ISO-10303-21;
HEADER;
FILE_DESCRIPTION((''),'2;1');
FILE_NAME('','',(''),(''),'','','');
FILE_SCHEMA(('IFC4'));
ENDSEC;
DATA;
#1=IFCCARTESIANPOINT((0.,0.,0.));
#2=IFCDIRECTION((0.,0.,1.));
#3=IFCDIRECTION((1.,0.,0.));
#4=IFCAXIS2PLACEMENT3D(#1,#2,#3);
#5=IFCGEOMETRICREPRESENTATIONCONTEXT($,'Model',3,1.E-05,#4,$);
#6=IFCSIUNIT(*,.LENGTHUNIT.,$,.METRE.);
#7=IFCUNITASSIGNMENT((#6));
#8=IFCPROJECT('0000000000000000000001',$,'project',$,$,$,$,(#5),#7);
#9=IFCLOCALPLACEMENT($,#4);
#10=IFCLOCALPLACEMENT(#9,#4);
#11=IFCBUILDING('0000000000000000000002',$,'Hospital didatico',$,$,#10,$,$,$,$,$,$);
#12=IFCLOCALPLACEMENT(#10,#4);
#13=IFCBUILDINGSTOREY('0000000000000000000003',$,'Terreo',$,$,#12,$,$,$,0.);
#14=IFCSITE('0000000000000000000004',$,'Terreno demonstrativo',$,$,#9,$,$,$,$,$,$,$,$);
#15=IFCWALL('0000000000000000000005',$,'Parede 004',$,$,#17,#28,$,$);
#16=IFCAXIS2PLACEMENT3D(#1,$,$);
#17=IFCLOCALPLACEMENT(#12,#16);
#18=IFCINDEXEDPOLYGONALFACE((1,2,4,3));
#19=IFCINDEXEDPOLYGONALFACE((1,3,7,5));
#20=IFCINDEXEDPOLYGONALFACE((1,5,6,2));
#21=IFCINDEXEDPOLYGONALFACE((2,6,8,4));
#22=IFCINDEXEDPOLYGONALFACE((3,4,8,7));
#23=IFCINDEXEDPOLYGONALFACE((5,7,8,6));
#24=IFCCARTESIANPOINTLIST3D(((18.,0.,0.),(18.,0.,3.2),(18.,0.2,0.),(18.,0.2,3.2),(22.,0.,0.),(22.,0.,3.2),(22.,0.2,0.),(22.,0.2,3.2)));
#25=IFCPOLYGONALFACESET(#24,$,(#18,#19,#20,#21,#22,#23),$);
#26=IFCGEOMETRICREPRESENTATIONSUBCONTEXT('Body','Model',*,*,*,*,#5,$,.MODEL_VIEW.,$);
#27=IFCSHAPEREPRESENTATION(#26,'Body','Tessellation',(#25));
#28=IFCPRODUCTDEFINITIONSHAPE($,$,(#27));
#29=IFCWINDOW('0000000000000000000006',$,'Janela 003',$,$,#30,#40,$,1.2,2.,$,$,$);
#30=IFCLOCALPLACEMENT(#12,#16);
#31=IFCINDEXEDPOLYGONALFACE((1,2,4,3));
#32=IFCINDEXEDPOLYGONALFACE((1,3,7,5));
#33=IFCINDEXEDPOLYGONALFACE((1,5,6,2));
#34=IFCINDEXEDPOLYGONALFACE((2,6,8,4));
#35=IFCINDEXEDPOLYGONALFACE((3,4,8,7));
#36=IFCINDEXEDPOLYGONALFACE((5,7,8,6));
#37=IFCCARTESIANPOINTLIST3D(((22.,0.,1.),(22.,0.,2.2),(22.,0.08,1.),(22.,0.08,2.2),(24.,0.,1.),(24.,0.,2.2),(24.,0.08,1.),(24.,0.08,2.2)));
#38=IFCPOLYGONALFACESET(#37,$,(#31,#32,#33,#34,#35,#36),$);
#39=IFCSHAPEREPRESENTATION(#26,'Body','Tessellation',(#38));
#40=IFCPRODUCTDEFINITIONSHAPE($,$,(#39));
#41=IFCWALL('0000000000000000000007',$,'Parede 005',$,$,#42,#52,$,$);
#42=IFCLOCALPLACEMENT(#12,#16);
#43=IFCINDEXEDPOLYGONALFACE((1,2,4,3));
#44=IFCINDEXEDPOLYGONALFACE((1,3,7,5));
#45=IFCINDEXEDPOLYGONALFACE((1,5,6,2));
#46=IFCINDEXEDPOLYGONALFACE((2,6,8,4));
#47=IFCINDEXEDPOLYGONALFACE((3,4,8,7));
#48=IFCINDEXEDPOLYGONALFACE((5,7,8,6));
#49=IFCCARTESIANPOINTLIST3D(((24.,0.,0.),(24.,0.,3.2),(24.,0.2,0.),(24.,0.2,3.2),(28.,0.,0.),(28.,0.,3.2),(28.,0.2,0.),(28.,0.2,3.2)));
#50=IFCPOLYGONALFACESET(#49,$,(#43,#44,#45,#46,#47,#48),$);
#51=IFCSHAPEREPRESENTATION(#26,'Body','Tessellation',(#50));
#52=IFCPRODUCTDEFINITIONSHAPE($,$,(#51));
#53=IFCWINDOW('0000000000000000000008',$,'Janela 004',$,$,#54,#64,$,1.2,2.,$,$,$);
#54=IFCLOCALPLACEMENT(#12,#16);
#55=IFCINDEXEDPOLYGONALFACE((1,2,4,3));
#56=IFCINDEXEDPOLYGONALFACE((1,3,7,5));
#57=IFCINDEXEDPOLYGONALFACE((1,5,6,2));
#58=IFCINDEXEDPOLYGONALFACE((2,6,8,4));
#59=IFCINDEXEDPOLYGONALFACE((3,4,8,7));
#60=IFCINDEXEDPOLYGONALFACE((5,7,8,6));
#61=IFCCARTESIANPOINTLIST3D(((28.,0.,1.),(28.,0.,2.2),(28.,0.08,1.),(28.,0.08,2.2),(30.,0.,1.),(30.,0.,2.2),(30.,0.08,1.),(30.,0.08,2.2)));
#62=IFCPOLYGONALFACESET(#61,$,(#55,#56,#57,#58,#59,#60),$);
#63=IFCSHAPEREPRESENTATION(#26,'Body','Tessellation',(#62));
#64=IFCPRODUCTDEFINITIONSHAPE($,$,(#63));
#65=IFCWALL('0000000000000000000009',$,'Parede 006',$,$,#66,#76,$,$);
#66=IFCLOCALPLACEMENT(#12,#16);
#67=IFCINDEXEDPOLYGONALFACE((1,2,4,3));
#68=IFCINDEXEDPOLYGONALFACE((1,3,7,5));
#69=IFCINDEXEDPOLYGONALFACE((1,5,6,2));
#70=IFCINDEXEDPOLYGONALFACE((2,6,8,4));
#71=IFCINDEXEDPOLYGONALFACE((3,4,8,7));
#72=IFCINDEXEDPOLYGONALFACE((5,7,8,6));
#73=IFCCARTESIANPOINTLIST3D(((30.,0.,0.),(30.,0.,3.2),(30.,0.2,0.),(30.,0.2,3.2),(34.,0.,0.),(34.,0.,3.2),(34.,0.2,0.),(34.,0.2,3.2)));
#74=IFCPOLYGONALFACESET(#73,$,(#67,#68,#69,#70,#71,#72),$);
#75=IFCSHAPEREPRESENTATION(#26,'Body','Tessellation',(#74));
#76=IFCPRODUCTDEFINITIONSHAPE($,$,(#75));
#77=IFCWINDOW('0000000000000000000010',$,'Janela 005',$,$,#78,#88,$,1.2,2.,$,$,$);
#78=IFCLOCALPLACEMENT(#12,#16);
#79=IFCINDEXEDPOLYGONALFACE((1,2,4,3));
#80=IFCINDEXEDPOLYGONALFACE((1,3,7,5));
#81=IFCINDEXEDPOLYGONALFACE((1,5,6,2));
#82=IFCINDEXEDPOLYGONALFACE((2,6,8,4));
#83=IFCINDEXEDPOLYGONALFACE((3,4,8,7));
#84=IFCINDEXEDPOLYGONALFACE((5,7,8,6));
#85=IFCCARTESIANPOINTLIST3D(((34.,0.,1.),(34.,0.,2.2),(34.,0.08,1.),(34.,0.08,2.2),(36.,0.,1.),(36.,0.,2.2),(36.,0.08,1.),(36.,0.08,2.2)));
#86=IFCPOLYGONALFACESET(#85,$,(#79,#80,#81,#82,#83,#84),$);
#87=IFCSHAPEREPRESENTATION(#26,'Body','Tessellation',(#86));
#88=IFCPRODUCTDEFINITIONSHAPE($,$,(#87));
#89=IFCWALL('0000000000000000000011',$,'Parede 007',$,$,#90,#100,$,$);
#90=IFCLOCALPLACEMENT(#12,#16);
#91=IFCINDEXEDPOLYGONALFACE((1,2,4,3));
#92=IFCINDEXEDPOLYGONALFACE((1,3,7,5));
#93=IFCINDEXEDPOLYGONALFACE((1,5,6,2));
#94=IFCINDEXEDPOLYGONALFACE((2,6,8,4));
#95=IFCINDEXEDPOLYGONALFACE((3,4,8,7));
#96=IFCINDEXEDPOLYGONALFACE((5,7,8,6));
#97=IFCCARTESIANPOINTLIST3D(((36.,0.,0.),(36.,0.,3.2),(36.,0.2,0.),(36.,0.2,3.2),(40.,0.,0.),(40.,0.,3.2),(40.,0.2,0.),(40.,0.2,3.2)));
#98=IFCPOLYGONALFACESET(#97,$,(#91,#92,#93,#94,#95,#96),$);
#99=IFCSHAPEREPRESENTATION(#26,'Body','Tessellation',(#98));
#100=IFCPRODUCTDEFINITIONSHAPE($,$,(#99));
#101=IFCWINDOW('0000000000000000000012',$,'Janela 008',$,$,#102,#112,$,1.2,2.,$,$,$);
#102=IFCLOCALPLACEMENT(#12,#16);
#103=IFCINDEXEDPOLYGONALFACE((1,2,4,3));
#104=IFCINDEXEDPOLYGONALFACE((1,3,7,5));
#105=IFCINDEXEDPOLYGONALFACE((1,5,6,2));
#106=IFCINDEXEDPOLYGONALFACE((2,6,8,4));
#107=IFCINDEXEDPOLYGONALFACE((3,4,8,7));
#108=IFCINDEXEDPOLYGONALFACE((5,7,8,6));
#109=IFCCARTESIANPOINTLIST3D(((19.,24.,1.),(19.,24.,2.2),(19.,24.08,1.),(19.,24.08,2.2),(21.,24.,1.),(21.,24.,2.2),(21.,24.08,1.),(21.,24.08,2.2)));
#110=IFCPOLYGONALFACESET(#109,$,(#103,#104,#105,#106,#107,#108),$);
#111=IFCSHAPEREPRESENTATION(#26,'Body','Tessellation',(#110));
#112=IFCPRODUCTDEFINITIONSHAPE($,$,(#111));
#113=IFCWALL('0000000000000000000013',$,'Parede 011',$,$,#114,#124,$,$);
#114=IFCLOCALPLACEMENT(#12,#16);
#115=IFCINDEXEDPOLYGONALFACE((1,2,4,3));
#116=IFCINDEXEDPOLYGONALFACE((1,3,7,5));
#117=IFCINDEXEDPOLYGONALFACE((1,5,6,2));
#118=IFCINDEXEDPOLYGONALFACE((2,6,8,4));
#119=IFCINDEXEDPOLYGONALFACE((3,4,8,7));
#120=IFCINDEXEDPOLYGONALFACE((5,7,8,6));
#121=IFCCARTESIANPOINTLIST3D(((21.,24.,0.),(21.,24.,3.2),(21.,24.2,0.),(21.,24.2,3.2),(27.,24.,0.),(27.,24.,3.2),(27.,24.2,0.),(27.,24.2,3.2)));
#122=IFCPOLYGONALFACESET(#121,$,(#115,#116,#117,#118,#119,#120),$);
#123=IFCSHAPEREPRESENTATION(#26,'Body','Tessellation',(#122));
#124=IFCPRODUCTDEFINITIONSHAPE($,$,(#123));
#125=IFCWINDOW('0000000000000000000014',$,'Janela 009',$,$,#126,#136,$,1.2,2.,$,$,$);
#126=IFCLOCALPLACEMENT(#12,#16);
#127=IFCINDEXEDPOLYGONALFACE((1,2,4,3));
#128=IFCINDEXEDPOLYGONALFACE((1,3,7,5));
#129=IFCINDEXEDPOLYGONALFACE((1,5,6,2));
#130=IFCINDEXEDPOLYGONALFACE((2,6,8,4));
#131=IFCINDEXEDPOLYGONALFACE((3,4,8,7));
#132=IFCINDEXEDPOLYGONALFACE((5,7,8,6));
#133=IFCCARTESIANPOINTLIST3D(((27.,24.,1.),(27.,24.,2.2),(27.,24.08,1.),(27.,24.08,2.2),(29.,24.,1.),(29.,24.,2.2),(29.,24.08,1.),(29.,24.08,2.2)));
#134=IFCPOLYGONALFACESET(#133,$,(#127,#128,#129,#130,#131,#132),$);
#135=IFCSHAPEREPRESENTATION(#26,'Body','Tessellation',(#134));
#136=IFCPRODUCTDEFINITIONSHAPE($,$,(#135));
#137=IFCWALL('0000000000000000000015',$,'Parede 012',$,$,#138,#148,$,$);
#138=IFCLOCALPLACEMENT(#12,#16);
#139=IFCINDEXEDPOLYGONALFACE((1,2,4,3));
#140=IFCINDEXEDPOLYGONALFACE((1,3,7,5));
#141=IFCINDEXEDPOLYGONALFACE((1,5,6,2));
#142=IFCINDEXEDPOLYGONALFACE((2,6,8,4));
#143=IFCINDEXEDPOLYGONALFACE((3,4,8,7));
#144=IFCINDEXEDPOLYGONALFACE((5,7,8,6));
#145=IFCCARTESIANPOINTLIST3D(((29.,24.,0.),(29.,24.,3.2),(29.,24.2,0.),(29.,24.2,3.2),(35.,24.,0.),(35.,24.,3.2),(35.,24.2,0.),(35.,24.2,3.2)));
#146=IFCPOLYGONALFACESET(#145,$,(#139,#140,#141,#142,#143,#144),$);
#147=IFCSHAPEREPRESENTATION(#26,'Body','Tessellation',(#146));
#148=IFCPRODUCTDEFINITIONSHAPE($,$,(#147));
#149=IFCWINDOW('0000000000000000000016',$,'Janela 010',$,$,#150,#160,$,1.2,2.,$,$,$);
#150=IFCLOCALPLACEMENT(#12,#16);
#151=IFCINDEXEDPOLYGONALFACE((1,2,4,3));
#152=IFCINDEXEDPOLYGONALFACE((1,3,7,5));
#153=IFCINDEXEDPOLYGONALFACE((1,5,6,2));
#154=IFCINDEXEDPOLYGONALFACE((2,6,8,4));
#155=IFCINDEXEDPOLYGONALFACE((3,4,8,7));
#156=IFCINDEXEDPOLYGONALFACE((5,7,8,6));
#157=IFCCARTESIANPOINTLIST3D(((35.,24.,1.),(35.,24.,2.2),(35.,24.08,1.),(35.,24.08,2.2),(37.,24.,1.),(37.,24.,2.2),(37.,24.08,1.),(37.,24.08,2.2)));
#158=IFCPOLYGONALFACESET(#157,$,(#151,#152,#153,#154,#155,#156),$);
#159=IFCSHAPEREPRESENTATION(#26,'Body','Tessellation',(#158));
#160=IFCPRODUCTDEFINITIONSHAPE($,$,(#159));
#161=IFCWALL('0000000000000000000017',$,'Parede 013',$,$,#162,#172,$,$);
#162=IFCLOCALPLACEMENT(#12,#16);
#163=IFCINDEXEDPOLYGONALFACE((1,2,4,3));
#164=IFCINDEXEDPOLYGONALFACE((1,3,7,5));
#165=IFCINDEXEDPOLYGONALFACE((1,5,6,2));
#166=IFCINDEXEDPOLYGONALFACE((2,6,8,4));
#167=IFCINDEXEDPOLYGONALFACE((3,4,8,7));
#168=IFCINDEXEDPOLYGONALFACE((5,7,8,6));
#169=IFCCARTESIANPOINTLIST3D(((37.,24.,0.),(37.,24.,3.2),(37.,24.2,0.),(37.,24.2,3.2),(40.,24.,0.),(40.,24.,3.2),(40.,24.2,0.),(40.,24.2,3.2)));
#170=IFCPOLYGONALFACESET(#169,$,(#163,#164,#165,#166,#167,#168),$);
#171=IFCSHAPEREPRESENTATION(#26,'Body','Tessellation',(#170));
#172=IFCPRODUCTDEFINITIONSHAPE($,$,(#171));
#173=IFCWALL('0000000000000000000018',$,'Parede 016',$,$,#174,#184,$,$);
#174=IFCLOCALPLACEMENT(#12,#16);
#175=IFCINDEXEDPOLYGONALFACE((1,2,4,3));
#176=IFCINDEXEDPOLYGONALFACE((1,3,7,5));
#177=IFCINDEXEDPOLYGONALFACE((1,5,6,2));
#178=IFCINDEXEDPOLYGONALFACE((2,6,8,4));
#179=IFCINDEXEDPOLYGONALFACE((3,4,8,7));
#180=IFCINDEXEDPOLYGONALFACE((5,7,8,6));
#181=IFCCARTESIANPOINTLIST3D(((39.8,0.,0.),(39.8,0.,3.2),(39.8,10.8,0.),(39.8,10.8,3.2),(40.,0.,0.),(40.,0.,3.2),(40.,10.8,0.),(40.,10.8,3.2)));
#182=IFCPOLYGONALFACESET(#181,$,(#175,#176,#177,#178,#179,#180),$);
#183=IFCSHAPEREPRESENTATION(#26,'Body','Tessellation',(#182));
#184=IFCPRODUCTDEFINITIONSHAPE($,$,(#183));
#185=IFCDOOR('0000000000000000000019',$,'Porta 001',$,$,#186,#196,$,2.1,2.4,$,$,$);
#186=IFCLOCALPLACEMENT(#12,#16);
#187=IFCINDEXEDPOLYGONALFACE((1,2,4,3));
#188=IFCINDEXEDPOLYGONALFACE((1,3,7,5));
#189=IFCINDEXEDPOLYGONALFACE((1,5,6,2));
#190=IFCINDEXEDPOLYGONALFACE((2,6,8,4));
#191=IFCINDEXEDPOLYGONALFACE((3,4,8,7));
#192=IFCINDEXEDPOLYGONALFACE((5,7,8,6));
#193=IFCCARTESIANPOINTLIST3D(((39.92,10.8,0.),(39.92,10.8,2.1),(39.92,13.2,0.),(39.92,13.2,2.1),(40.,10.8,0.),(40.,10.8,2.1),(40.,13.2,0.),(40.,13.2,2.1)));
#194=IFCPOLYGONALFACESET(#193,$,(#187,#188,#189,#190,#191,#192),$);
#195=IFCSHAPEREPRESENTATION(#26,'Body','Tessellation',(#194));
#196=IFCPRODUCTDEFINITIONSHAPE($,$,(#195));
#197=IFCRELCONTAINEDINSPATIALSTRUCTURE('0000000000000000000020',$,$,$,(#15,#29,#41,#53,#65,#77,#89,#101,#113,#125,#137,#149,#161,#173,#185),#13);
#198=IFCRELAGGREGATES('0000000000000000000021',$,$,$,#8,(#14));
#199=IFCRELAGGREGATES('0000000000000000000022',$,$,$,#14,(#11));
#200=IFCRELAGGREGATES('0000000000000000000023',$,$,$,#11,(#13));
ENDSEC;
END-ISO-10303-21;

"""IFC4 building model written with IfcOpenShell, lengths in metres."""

from ifc_helpers import new_model, si_unit, frame, origin_with_axes, place, context, subcontext, project, spatial, indexed_curve, outline, extrude, element, save


model = new_model("IFC4")

# Units and contexts
model_context = context("Model", 3, precision=1e-05, world=origin_with_axes())
body_context = subcontext(model_context, "Body", "Model", "MODEL_VIEW")
ifc_project = project(units=[si_unit("LENGTHUNIT", "METRE")], contexts=[model_context])

# Site, building, storey
site_placement = place(None, origin_with_axes())
site = spatial("IfcSite", under=ifc_project, at=site_placement, Name="Terreno demonstrativo")
building_placement = place(site_placement, origin_with_axes())
building = spatial("IfcBuilding", under=site, at=building_placement, Name="Hospital didatico")
storey_placement = place(building_placement, origin_with_axes())
storey = spatial("IfcBuildingStorey", under=building, at=storey_placement, Name="Terreo", Elevation=0.0)

# Wall
wall_1_placement = place(storey_placement, frame((18.0, 0.0, 0.0), z_axis=(0.0, 0.0, 1.0), x_axis=(1.0, 0.0, 0.0)))
element("IfcWall", 1, at=wall_1_placement, inside=storey, Name="Parede 004", context=body_context, shape_type="SweptSolid", body=[
    extrude(outline(indexed_curve([(0.0, 0.0), (0.0, 0.2), (4.0, 0.2), (4.0, 0.0), (0.0, 0.0)], self_intersect=False)), origin_with_axes(), (0.0, 0.0, 1.0), 3.2),
])

# Window
window_1_placement = place(storey_placement, frame((22.0, 0.0, 1.0), z_axis=(0.0, 0.0, 1.0), x_axis=(1.0, 0.0, 0.0)))
element("IfcWindow", 2, at=window_1_placement, inside=storey, Name="Janela 003", OverallHeight=1.2, OverallWidth=2.0, context=body_context, shape_type="SweptSolid", body=[
    extrude(outline(indexed_curve([(0.0, 0.0), (0.0, 0.08), (2.0, 0.08), (2.0, 0.0), (0.0, 0.0)], self_intersect=False)), origin_with_axes(), (0.0, 0.0, 1.0), 1.2),
])

# Wall
wall_2_placement = place(storey_placement, frame((24.0, 0.0, 0.0), z_axis=(0.0, 0.0, 1.0), x_axis=(1.0, 0.0, 0.0)))
element("IfcWall", 3, at=wall_2_placement, inside=storey, Name="Parede 005", context=body_context, shape_type="SweptSolid", body=[
    extrude(outline(indexed_curve([(0.0, 0.0), (0.0, 0.2), (4.0, 0.2), (4.0, 0.0), (0.0, 0.0)], self_intersect=False)), origin_with_axes(), (0.0, 0.0, 1.0), 3.2),
])

# Window
window_2_placement = place(storey_placement, frame((28.0, 0.0, 1.0), z_axis=(0.0, 0.0, 1.0), x_axis=(1.0, 0.0, 0.0)))
element("IfcWindow", 4, at=window_2_placement, inside=storey, Name="Janela 004", OverallHeight=1.2, OverallWidth=2.0, context=body_context, shape_type="SweptSolid", body=[
    extrude(outline(indexed_curve([(0.0, 0.0), (0.0, 0.08), (2.0, 0.08), (2.0, 0.0), (0.0, 0.0)], self_intersect=False)), origin_with_axes(), (0.0, 0.0, 1.0), 1.2),
])

# Wall
wall_3_placement = place(storey_placement, frame((30.0, 0.0, 0.0), z_axis=(0.0, 0.0, 1.0), x_axis=(1.0, 0.0, 0.0)))
element("IfcWall", 5, at=wall_3_placement, inside=storey, Name="Parede 006", context=body_context, shape_type="SweptSolid", body=[
    extrude(outline(indexed_curve([(0.0, 0.0), (0.0, 0.2), (4.0, 0.2), (4.0, 0.0), (0.0, 0.0)], self_intersect=False)), origin_with_axes(), (0.0, 0.0, 1.0), 3.2),
])

# Window
window_3_placement = place(storey_placement, frame((34.0, 0.0, 1.0), z_axis=(0.0, 0.0, 1.0), x_axis=(1.0, 0.0, 0.0)))
element("IfcWindow", 6, at=window_3_placement, inside=storey, Name="Janela 005", OverallHeight=1.2, OverallWidth=2.0, context=body_context, shape_type="SweptSolid", body=[
    extrude(outline(indexed_curve([(0.0, 0.0), (0.0, 0.08), (2.0, 0.08), (2.0, 0.0), (0.0, 0.0)], self_intersect=False)), origin_with_axes(), (0.0, 0.0, 1.0), 1.2),
])

# Wall
wall_4_placement = place(storey_placement, frame((36.0, 0.0, 0.0), z_axis=(0.0, 0.0, 1.0), x_axis=(1.0, 0.0, 0.0)))
element("IfcWall", 7, at=wall_4_placement, inside=storey, Name="Parede 007", context=body_context, shape_type="SweptSolid", body=[
    extrude(outline(indexed_curve([(0.0, 0.0), (0.0, 0.2), (4.0, 0.2), (4.0, 0.0), (0.0, 0.0)], self_intersect=False)), origin_with_axes(), (0.0, 0.0, 1.0), 3.2),
])

# Window
window_4_placement = place(storey_placement, frame((19.0, 24.0, 1.0), z_axis=(0.0, 0.0, 1.0), x_axis=(1.0, 0.0, 0.0)))
element("IfcWindow", 8, at=window_4_placement, inside=storey, Name="Janela 008", OverallHeight=1.2, OverallWidth=2.0, context=body_context, shape_type="SweptSolid", body=[
    extrude(outline(indexed_curve([(0.0, 0.0), (0.0, 0.08), (2.0, 0.08), (2.0, 0.0), (0.0, 0.0)], self_intersect=False)), origin_with_axes(), (0.0, 0.0, 1.0), 1.2),
])

# Wall
wall_5_placement = place(storey_placement, frame((21.0, 24.0, 0.0), z_axis=(0.0, 0.0, 1.0), x_axis=(1.0, 0.0, 0.0)))
element("IfcWall", 9, at=wall_5_placement, inside=storey, Name="Parede 011", context=body_context, shape_type="SweptSolid", body=[
    extrude(outline(indexed_curve([(0.0, 0.0), (0.0, 0.2), (6.0, 0.2), (6.0, 0.0), (0.0, 0.0)], self_intersect=False)), origin_with_axes(), (0.0, 0.0, 1.0), 3.2),
])

# Window
window_5_placement = place(storey_placement, frame((27.0, 24.0, 1.0), z_axis=(0.0, 0.0, 1.0), x_axis=(1.0, 0.0, 0.0)))
element("IfcWindow", 10, at=window_5_placement, inside=storey, Name="Janela 009", OverallHeight=1.2, OverallWidth=2.0, context=body_context, shape_type="SweptSolid", body=[
    extrude(outline(indexed_curve([(0.0, 0.0), (0.0, 0.08), (2.0, 0.08), (2.0, 0.0), (0.0, 0.0)], self_intersect=False)), origin_with_axes(), (0.0, 0.0, 1.0), 1.2),
])

# Wall
wall_6_placement = place(storey_placement, frame((29.0, 24.0, 0.0), z_axis=(0.0, 0.0, 1.0), x_axis=(1.0, 0.0, 0.0)))
element("IfcWall", 11, at=wall_6_placement, inside=storey, Name="Parede 012", context=body_context, shape_type="SweptSolid", body=[
    extrude(outline(indexed_curve([(0.0, 0.0), (0.0, 0.2), (6.0, 0.2), (6.0, 0.0), (0.0, 0.0)], self_intersect=False)), origin_with_axes(), (0.0, 0.0, 1.0), 3.2),
])

# Window
window_6_placement = place(storey_placement, frame((35.0, 24.0, 1.0), z_axis=(0.0, 0.0, 1.0), x_axis=(1.0, 0.0, 0.0)))
element("IfcWindow", 12, at=window_6_placement, inside=storey, Name="Janela 010", OverallHeight=1.2, OverallWidth=2.0, context=body_context, shape_type="SweptSolid", body=[
    extrude(outline(indexed_curve([(0.0, 0.0), (0.0, 0.08), (2.0, 0.08), (2.0, 0.0), (0.0, 0.0)], self_intersect=False)), origin_with_axes(), (0.0, 0.0, 1.0), 1.2),
])

# Walls
wall_7_placement = place(storey_placement, frame((37.0, 24.0, 0.0), z_axis=(0.0, 0.0, 1.0), x_axis=(1.0, 0.0, 0.0)))
element("IfcWall", 13, at=wall_7_placement, inside=storey, Name="Parede 013", context=body_context, shape_type="SweptSolid", body=[
    extrude(outline(indexed_curve([(0.0, 0.0), (0.0, 0.2), (3.0, 0.2), (3.0, 0.0), (0.0, 0.0)], self_intersect=False)), origin_with_axes(), (0.0, 0.0, 1.0), 3.2),
])
wall_8_placement = place(storey_placement, frame((40.0, 0.0, 0.0), z_axis=(0.0, 0.0, 1.0), x_axis=(0.0, 1.0, 0.0)))
element("IfcWall", 14, at=wall_8_placement, inside=storey, Name="Parede 016", context=body_context, shape_type="SweptSolid", body=[
    extrude(outline(indexed_curve([(0.0, 0.0), (0.0, 0.2), (10.8, 0.2), (10.8, 0.0), (0.0, 0.0)], self_intersect=False)), origin_with_axes(), (0.0, 0.0, 1.0), 3.2),
])

# Door
door_1_placement = place(storey_placement, frame((40.0, 10.8, 0.0), z_axis=(0.0, 0.0, 1.0), x_axis=(0.0, 1.0, 0.0)))
element("IfcDoor", 15, at=door_1_placement, inside=storey, Name="Porta 001", OverallHeight=2.1, OverallWidth=2.4, context=body_context, shape_type="SweptSolid", body=[
    extrude(outline(indexed_curve([(0.0, 0.0), (0.0, 0.08), (2.4, 0.08), (2.4, 0.0), (0.0, 0.0)], self_intersect=False)), origin_with_axes(), (0.0, 0.0, 1.0), 2.1),
])

save(model, "model.ifc")
